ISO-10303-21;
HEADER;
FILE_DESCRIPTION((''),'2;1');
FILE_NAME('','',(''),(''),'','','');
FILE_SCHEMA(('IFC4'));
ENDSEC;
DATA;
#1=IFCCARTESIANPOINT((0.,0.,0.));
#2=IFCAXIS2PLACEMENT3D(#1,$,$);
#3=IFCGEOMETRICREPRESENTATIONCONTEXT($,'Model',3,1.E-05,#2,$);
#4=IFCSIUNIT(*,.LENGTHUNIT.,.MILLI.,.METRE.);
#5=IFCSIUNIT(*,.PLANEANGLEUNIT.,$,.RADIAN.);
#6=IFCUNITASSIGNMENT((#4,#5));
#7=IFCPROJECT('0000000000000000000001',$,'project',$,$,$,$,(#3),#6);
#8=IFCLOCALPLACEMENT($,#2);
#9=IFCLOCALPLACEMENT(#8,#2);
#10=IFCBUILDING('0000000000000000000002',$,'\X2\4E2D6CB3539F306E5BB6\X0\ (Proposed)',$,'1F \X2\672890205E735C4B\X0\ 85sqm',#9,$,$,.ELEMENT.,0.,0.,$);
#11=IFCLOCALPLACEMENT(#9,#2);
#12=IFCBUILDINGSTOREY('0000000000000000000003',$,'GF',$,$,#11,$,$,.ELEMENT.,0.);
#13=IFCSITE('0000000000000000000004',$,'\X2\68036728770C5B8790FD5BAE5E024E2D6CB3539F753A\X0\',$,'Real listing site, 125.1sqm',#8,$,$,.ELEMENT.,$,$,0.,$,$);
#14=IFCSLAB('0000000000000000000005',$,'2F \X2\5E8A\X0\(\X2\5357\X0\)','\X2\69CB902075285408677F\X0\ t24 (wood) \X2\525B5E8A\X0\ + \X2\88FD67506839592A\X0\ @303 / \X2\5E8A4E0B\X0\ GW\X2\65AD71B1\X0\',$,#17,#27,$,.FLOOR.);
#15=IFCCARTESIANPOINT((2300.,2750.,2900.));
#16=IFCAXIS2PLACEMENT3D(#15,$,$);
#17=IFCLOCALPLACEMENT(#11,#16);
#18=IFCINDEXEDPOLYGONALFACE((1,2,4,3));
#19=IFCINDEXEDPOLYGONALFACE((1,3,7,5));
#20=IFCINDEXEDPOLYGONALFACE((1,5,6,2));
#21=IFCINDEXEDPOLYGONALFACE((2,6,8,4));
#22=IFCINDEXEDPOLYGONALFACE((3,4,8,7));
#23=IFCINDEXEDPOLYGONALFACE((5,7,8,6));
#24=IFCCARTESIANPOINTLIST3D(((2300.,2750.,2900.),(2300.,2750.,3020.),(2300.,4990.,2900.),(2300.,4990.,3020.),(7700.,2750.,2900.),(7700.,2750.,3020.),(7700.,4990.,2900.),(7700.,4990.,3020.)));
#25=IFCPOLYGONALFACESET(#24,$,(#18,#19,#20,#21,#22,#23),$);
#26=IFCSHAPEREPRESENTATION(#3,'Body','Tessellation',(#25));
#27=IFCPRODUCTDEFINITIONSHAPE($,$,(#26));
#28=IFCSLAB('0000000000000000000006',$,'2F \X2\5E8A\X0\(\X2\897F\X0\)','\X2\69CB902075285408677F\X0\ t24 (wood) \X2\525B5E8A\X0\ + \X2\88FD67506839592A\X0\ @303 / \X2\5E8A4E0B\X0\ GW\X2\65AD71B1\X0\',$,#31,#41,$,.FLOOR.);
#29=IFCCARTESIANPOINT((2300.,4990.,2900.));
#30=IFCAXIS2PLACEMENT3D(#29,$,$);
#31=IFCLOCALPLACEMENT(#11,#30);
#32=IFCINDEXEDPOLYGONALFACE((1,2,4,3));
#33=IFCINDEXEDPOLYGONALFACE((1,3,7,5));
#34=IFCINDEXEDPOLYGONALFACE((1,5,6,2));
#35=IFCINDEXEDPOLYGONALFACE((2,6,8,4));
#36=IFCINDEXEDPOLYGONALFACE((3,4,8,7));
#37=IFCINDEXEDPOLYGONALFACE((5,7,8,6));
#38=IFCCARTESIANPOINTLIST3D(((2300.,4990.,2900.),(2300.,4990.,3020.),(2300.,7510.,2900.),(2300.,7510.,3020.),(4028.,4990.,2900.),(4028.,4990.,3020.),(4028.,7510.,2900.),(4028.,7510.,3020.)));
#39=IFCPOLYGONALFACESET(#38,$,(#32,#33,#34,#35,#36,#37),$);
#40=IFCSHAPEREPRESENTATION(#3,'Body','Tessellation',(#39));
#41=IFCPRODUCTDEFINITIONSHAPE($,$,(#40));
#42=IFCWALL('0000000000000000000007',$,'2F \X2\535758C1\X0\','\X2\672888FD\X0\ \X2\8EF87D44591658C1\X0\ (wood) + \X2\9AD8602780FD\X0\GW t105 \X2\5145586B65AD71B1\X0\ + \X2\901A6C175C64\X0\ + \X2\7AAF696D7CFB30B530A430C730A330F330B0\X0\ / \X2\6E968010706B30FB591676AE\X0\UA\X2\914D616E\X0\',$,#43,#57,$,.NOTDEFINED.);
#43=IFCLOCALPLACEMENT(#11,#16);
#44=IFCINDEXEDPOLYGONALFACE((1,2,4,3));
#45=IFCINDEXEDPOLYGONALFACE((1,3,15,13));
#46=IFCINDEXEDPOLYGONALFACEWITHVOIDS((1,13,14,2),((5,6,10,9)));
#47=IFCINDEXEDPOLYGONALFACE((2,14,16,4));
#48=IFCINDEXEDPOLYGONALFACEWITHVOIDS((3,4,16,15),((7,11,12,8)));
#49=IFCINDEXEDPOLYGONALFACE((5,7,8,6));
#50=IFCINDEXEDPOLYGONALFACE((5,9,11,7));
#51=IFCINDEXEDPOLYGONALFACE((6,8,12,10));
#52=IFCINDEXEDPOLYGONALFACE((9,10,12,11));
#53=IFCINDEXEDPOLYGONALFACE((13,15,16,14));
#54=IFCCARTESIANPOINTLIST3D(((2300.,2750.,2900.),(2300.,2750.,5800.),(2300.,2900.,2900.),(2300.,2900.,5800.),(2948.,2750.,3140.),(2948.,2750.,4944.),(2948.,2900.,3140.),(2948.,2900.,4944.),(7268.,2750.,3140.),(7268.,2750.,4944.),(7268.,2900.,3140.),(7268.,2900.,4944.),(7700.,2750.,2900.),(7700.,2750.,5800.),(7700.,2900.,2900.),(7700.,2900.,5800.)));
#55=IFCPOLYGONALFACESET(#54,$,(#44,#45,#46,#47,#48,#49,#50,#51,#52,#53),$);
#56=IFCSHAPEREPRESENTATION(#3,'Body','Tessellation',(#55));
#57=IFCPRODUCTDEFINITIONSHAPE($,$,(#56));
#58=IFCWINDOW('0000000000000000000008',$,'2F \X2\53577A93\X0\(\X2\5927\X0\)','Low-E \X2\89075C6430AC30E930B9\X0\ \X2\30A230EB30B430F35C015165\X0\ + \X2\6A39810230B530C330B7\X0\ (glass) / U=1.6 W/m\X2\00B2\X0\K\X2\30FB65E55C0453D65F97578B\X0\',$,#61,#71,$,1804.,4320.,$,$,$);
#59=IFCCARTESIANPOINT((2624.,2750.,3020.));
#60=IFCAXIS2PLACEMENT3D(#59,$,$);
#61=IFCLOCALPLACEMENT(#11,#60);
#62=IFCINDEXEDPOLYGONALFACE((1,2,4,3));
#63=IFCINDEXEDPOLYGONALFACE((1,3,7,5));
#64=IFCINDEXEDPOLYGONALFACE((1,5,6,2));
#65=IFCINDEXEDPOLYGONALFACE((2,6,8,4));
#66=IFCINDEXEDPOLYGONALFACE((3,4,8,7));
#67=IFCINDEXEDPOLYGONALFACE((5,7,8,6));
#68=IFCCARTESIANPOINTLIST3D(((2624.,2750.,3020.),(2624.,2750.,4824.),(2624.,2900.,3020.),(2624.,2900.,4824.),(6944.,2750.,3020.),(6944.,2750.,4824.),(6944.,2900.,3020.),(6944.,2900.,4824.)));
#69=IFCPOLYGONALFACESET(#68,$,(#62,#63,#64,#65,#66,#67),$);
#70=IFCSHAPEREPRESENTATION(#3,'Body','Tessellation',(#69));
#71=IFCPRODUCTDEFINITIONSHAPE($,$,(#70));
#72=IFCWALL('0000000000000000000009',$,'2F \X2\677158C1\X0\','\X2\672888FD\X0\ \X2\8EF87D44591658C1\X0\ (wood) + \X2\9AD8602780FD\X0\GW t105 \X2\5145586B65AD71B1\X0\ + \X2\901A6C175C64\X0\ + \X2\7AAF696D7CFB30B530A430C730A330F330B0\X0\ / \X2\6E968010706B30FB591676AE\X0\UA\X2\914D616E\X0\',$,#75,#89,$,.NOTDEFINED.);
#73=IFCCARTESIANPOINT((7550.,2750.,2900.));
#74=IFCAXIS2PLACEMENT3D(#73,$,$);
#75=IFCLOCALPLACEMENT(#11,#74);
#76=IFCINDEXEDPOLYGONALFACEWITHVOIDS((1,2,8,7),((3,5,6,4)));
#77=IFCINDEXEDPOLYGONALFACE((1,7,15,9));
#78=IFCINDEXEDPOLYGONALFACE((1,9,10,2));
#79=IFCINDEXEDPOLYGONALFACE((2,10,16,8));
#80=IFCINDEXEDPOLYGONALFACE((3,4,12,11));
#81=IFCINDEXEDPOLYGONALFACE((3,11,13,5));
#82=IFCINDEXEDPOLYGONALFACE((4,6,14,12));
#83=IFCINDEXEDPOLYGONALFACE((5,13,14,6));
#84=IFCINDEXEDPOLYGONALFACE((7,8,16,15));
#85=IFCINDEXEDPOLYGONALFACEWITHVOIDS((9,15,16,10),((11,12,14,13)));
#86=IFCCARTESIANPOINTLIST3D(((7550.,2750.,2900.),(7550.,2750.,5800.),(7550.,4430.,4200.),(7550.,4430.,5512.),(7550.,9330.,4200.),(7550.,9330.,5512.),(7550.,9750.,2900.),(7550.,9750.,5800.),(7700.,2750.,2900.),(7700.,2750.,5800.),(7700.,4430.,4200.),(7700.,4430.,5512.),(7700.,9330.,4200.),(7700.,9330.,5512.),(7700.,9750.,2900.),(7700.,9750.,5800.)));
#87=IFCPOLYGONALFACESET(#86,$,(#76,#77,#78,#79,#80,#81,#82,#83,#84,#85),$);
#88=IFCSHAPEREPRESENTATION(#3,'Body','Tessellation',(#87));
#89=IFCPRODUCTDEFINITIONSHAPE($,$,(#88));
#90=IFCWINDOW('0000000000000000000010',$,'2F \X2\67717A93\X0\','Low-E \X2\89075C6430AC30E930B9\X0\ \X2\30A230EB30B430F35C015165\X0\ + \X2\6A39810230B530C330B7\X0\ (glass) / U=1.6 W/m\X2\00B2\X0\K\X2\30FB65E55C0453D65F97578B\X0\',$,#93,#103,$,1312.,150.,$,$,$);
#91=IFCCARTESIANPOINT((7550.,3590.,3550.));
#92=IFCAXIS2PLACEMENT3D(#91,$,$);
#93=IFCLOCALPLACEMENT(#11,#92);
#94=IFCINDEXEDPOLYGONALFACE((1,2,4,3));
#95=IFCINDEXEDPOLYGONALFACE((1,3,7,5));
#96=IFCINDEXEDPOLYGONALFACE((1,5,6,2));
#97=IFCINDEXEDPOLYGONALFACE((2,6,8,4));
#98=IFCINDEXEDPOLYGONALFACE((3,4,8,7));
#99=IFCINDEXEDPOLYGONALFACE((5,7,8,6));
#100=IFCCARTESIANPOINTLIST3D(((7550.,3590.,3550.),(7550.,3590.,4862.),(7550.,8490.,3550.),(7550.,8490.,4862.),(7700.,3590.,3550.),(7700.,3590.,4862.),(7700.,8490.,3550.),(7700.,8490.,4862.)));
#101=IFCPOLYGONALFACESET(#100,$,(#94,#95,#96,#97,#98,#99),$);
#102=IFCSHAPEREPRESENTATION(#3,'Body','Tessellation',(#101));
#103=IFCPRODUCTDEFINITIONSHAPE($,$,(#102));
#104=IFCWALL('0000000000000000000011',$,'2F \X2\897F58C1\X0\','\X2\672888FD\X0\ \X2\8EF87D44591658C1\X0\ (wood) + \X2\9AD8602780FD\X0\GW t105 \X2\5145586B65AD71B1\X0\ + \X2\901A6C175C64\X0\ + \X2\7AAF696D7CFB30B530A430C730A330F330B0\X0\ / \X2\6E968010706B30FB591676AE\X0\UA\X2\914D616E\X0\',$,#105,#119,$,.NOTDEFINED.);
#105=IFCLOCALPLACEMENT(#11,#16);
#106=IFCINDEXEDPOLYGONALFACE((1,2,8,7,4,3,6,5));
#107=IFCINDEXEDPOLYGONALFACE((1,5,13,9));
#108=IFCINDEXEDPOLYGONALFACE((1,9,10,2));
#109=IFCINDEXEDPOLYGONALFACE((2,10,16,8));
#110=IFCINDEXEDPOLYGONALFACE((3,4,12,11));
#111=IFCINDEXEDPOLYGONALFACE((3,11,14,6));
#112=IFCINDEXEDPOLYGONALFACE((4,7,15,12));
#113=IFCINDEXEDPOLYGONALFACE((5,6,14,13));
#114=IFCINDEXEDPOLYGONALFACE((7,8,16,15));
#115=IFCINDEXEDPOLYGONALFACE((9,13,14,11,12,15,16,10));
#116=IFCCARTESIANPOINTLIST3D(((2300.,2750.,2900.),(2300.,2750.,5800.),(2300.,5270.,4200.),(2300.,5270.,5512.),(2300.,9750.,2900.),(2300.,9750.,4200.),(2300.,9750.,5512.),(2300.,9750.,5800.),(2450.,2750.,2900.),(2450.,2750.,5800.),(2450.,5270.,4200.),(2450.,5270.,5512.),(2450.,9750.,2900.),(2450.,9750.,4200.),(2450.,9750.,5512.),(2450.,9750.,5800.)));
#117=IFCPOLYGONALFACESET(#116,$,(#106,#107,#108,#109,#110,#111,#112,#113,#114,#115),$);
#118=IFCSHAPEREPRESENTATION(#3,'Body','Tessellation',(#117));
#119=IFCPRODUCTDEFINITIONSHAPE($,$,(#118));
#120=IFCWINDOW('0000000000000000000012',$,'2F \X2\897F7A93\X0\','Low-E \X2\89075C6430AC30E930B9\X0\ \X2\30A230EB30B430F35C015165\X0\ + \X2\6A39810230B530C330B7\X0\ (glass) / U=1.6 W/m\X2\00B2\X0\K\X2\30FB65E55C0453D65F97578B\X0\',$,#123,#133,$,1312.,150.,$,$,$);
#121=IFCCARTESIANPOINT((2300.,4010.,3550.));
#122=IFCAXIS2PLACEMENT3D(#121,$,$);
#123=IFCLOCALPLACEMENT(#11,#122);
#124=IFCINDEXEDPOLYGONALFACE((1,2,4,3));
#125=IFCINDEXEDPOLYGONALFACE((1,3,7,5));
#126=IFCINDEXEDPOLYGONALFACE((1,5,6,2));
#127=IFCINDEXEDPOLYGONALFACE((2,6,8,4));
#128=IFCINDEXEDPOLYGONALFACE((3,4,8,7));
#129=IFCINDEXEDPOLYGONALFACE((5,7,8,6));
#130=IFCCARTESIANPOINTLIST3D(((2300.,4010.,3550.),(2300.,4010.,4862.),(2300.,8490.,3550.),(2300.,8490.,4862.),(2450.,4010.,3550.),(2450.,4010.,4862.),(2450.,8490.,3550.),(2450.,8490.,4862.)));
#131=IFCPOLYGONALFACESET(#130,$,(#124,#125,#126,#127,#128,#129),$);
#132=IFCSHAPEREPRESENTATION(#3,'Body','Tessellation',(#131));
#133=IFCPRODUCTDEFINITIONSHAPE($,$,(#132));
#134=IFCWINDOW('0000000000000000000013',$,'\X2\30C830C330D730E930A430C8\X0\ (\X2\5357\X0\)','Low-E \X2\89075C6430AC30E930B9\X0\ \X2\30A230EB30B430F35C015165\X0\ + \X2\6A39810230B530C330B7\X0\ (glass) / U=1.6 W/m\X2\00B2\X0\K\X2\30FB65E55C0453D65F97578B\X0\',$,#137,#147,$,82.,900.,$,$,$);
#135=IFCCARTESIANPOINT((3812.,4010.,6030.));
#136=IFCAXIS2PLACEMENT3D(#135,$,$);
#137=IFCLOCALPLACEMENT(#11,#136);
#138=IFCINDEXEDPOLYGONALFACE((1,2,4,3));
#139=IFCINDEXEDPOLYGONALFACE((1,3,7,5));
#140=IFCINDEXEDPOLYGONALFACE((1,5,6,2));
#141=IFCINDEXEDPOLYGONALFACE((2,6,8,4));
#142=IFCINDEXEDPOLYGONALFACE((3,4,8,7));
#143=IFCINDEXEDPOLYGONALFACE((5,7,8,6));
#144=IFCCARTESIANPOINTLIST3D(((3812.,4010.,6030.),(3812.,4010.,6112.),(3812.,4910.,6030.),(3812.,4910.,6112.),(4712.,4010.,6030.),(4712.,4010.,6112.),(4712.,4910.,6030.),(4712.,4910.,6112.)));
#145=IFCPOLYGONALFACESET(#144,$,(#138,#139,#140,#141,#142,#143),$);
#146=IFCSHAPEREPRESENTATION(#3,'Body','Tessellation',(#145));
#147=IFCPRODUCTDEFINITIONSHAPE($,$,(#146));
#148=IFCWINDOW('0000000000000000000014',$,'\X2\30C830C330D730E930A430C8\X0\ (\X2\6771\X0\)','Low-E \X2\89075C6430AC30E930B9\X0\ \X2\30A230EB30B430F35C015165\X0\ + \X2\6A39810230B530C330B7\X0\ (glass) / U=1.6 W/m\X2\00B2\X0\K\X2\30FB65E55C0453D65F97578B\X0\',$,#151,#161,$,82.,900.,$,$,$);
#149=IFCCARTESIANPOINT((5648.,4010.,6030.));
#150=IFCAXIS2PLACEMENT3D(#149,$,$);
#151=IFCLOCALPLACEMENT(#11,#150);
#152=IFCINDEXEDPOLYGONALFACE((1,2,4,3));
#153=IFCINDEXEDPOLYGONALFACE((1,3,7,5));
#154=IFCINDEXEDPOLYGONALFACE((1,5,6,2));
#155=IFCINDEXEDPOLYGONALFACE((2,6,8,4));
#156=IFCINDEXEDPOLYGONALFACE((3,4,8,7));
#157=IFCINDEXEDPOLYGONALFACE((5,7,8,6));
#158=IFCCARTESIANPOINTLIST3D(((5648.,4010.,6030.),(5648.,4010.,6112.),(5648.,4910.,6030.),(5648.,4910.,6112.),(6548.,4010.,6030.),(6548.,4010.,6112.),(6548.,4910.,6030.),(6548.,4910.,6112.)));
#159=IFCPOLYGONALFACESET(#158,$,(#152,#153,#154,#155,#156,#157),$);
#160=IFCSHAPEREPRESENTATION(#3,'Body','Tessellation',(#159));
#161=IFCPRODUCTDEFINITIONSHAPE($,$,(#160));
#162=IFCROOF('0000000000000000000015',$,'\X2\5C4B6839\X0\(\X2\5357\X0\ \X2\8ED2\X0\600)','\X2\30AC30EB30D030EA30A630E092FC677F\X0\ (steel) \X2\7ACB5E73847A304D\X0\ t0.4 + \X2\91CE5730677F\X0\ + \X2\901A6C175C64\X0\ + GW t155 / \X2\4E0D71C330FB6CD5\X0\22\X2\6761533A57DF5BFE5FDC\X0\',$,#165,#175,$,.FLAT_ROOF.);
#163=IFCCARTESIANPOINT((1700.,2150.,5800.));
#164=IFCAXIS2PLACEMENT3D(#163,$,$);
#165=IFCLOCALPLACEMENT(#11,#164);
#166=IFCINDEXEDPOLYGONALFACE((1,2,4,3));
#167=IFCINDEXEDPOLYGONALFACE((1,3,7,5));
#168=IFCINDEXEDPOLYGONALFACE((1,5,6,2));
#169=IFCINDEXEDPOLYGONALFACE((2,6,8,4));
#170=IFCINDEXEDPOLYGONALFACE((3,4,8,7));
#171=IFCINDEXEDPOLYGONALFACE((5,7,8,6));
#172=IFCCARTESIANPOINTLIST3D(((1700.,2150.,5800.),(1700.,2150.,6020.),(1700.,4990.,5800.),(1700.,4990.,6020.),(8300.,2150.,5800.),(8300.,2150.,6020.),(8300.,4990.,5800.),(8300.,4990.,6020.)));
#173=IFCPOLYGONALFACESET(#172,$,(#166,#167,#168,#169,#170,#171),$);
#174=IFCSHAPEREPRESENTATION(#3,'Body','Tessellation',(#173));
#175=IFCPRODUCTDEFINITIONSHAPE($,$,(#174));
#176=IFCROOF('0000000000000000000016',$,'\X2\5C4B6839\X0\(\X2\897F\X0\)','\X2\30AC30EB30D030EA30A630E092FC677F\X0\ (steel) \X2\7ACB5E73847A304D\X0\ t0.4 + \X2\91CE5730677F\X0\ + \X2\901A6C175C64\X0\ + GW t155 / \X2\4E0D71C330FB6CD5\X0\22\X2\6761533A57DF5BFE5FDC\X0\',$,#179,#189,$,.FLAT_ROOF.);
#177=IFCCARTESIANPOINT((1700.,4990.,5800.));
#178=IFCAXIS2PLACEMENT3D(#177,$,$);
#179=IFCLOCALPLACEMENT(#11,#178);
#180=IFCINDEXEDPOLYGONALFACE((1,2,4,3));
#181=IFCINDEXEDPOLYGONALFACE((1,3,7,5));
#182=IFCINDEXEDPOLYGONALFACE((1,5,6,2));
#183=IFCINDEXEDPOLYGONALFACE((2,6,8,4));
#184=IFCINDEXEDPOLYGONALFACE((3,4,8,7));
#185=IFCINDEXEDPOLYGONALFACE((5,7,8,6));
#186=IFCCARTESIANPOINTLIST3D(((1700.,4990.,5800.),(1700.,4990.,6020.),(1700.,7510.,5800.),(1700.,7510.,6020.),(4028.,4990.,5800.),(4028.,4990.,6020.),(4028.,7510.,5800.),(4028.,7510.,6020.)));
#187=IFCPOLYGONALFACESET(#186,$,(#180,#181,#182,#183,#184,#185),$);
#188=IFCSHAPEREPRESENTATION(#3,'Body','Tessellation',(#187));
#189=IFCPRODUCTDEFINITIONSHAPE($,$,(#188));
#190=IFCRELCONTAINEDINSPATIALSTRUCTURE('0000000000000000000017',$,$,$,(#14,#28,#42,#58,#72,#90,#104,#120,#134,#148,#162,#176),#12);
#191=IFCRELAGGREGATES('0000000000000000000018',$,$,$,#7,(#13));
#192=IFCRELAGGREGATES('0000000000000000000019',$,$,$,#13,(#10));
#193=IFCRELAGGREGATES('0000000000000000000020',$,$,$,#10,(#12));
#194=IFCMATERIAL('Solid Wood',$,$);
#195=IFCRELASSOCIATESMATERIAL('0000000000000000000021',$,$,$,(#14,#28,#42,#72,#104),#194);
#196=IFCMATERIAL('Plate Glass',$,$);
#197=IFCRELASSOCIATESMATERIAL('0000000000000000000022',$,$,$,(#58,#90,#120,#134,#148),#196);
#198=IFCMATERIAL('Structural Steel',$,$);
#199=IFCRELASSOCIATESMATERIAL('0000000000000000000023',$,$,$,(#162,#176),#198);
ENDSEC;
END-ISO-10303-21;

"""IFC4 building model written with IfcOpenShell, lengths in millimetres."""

from ifc_helpers import new_model, si_unit, frame, frame_2d, origin, place, context, project, spatial, rectangle, extrude, material, element, fill, save


model = new_model("IFC4")

# Units and contexts
model_context = context("Model", 3, precision=1e-05, world=origin())
ifc_project = project(units=[si_unit("LENGTHUNIT", "METRE", prefix="MILLI"), si_unit("PLANEANGLEUNIT", "RADIAN")], contexts=[model_context])

# Site, building, storey
site_placement = place(None, origin())
site = spatial("IfcSite", under=ifc_project, at=site_placement, Name="栃木県宇都宮市中河原町", ObjectType="Real listing site, 125.1sqm", CompositionType="ELEMENT", RefElevation=0.0)
building_placement = place(site_placement, origin())
building = spatial("IfcBuilding", under=site, at=building_placement, Name="中河原の家 (Proposed)", ObjectType="1F 木造平屋 85sqm", CompositionType="ELEMENT", ElevationOfRefHeight=0.0, ElevationOfTerrain=0.0)
storey_placement = place(building_placement, origin())
storey = spatial("IfcBuildingStorey", under=building, at=storey_placement, Name="GF", CompositionType="ELEMENT", Elevation=0.0)

# Slabs
ifc_material_1 = material(Name="Solid Wood")
slab_1_placement = place(storey_placement, frame((2300.0, 2750.0, 2900.0)))
element("IfcSlab", 1, at=slab_1_placement, inside=storey, material=ifc_material_1, Name="2F 床(南)", Description="構造用合板 t24 (wood) 剛床 + 製材根太 @303 / 床下 GW断熱", PredefinedType="FLOOR", context=model_context, shape_type="SweptSolid", body=[
    extrude(rectangle(XDim=5400.0, YDim=2240.0, at=frame_2d((2700.0, 1120.0))), frame((2300.0, 2750.0, 2900.0)), (0.0, 0.0, 1.0), 120.0),
])
slab_2_placement = place(storey_placement, frame((2300.0, 4990.0, 2900.0)))
element("IfcSlab", 2, at=slab_2_placement, inside=storey, material=ifc_material_1, Name="2F 床(西)", Description="構造用合板 t24 (wood) 剛床 + 製材根太 @303 / 床下 GW断熱", PredefinedType="FLOOR", context=model_context, shape_type="SweptSolid", body=[
    extrude(rectangle(XDim=1728.0, YDim=2520.0, at=frame_2d((864.0, 1260.0))), frame((2300.0, 4990.0, 2900.0)), (0.0, 0.0, 1.0), 120.0),
])

# Walls, openings, windows
wall_1_placement = place(storey_placement, frame((2300.0, 2750.0, 2900.0)))
wall_1 = element("IfcWall", 3, at=wall_1_placement, inside=storey, material=ifc_material_1, Name="2F 南壁", Description="木製 軸組外壁 (wood) + 高性能GW t105 充填断熱 + 通気層 + 窯業系サイディング / 準耐火・外皮UA配慮", PredefinedType="NOTDEFINED", context=model_context, shape_type="SweptSolid", body=[
    extrude(rectangle(XDim=5400.0, YDim=150.0, at=frame_2d((2700.0, 75.0))), frame((2300.0, 2750.0, 2900.0)), (0.0, 0.0, 1.0), 2900.0),
])
opening_1_placement = place(storey_placement, frame((2624.0, 2750.0, 3020.0)))
opening_1 = element("IfcOpeningElement", 4, at=opening_1_placement, cuts=wall_1, PredefinedType="NOTDEFINED", context=model_context, shape_type="SweptSolid", body=[
    extrude(rectangle(XDim=4320.0, YDim=150.0, at=frame_2d((2160.0, 75.0))), frame((2624.0, 2750.0, 3020.0)), (0.0, 0.0, 1.0), 1804.0),
])
ifc_material_2 = material(Name="Plate Glass")
window_1_placement = place(storey_placement, frame((2624.0, 2750.0, 3020.0)))
window_1 = element("IfcWindow", 5, at=window_1_placement, inside=storey, material=ifc_material_2, Name="2F 南窓(大)", Description="Low-E 複層ガラス アルゴン封入 + 樹脂サッシ (glass) / U=1.6 W/m²K・日射取得型", OverallHeight=1804.0, OverallWidth=4320.0, context=model_context, shape_type="SweptSolid", body=[
    extrude(rectangle(XDim=4320.0, YDim=150.0, at=frame_2d((2160.0, 75.0))), frame((2624.0, 2750.0, 3020.0)), (0.0, 0.0, 1.0), 1804.0),
])
fill(opening_1, window_1)
wall_2_placement = place(storey_placement, frame((7550.0, 2750.0, 2900.0)))
wall_2 = element("IfcWall", 6, at=wall_2_placement, inside=storey, material=ifc_material_1, Name="2F 東壁", Description="木製 軸組外壁 (wood) + 高性能GW t105 充填断熱 + 通気層 + 窯業系サイディング / 準耐火・外皮UA配慮", PredefinedType="NOTDEFINED", context=model_context, shape_type="SweptSolid", body=[
    extrude(rectangle(XDim=150.0, YDim=7000.0, at=frame_2d((75.0, 3500.0))), frame((7550.0, 2750.0, 2900.0)), (0.0, 0.0, 1.0), 2900.0),
])
opening_2_placement = place(storey_placement, frame((7550.0, 3590.0, 3550.0)))
opening_2 = element("IfcOpeningElement", 7, at=opening_2_placement, cuts=wall_2, PredefinedType="NOTDEFINED", context=model_context, shape_type="SweptSolid", body=[
    extrude(rectangle(XDim=150.0, YDim=4900.0, at=frame_2d((75.0, 2450.0))), frame((7550.0, 3590.0, 3550.0)), (0.0, 0.0, 1.0), 1312.0),
])
window_2_placement = place(storey_placement, frame((7550.0, 3590.0, 3550.0)))
window_2 = element("IfcWindow", 8, at=window_2_placement, inside=storey, material=ifc_material_2, Name="2F 東窓", Description="Low-E 複層ガラス アルゴン封入 + 樹脂サッシ (glass) / U=1.6 W/m²K・日射取得型", OverallHeight=1312.0, OverallWidth=150.0, context=model_context, shape_type="SweptSolid", body=[
    extrude(rectangle(XDim=150.0, YDim=4900.0, at=frame_2d((75.0, 2450.0))), frame((7550.0, 3590.0, 3550.0)), (0.0, 0.0, 1.0), 1312.0),
])
fill(opening_2, window_2)
wall_3_placement = place(storey_placement, frame((2300.0, 2750.0, 2900.0)))
wall_3 = element("IfcWall", 9, at=wall_3_placement, inside=storey, material=ifc_material_1, Name="2F 西壁", Description="木製 軸組外壁 (wood) + 高性能GW t105 充填断熱 + 通気層 + 窯業系サイディング / 準耐火・外皮UA配慮", PredefinedType="NOTDEFINED", context=model_context, shape_type="SweptSolid", body=[
    extrude(rectangle(XDim=150.0, YDim=7000.0, at=frame_2d((75.0, 3500.0))), frame((2300.0, 2750.0, 2900.0)), (0.0, 0.0, 1.0), 2900.0),
])
opening_3_placement = place(storey_placement, frame((2300.0, 4010.0, 3550.0)))
opening_3 = element("IfcOpeningElement", 10, at=opening_3_placement, cuts=wall_3, PredefinedType="NOTDEFINED", context=model_context, shape_type="SweptSolid", body=[
    extrude(rectangle(XDim=150.0, YDim=4480.0, at=frame_2d((75.0, 2240.0))), frame((2300.0, 4010.0, 3550.0)), (0.0, 0.0, 1.0), 1312.0),
])
window_3_placement = place(storey_placement, frame((2300.0, 4010.0, 3550.0)))
window_3 = element("IfcWindow", 11, at=window_3_placement, inside=storey, material=ifc_material_2, Name="2F 西窓", Description="Low-E 複層ガラス アルゴン封入 + 樹脂サッシ (glass) / U=1.6 W/m²K・日射取得型", OverallHeight=1312.0, OverallWidth=150.0, context=model_context, shape_type="SweptSolid", body=[
    extrude(rectangle(XDim=150.0, YDim=4480.0, at=frame_2d((75.0, 2240.0))), frame((2300.0, 4010.0, 3550.0)), (0.0, 0.0, 1.0), 1312.0),
])
fill(opening_3, window_3)

# Windows
window_4_placement = place(storey_placement, frame((3812.0, 4010.0, 6030.0)))
element("IfcWindow", 12, at=window_4_placement, inside=storey, material=ifc_material_2, Name="トップライト (南)", Description="Low-E 複層ガラス アルゴン封入 + 樹脂サッシ (glass) / U=1.6 W/m²K・日射取得型", OverallHeight=82.0, OverallWidth=900.0, context=model_context, shape_type="SweptSolid", body=[
    extrude(rectangle(XDim=900.0, YDim=900.0, at=frame_2d((450.0, 450.0))), frame((3812.0, 4010.0, 6030.0)), (0.0, 0.0, 1.0), 82.0),
])
window_5_placement = place(storey_placement, frame((5648.0, 4010.0, 6030.0)))
element("IfcWindow", 13, at=window_5_placement, inside=storey, material=ifc_material_2, Name="トップライト (東)", Description="Low-E 複層ガラス アルゴン封入 + 樹脂サッシ (glass) / U=1.6 W/m²K・日射取得型", OverallHeight=82.0, OverallWidth=900.0, context=model_context, shape_type="SweptSolid", body=[
    extrude(rectangle(XDim=900.0, YDim=900.0, at=frame_2d((450.0, 450.0))), frame((5648.0, 4010.0, 6030.0)), (0.0, 0.0, 1.0), 82.0),
])

# Roofs
ifc_material_3 = material(Name="Structural Steel")
roof_1_placement = place(storey_placement, frame((1700.0, 2150.0, 5800.0)))
element("IfcRoof", 14, at=roof_1_placement, inside=storey, material=ifc_material_3, Name="屋根(南 軒600)", Description="ガルバリウム鋼板 (steel) 立平葺き t0.4 + 野地板 + 通気層 + GW t155 / 不燃・法22条区域対応", PredefinedType="FLAT_ROOF", context=model_context, shape_type="SweptSolid", body=[
    extrude(rectangle(XDim=6600.0, YDim=2840.0, at=frame_2d((3300.0, 1420.0))), frame((1700.0, 2150.0, 5800.0)), (0.0, 0.0, 1.0), 220.0),
])
roof_2_placement = place(storey_placement, frame((1700.0, 4990.0, 5800.0)))
element("IfcRoof", 15, at=roof_2_placement, inside=storey, material=ifc_material_3, Name="屋根(西)", Description="ガルバリウム鋼板 (steel) 立平葺き t0.4 + 野地板 + 通気層 + GW t155 / 不燃・法22条区域対応", PredefinedType="FLAT_ROOF", context=model_context, shape_type="SweptSolid", body=[
    extrude(rectangle(XDim=2328.0, YDim=2520.0, at=frame_2d((1164.0, 1260.0))), frame((1700.0, 4990.0, 5800.0)), (0.0, 0.0, 1.0), 220.0),
])

save(model, "model.ifc")
